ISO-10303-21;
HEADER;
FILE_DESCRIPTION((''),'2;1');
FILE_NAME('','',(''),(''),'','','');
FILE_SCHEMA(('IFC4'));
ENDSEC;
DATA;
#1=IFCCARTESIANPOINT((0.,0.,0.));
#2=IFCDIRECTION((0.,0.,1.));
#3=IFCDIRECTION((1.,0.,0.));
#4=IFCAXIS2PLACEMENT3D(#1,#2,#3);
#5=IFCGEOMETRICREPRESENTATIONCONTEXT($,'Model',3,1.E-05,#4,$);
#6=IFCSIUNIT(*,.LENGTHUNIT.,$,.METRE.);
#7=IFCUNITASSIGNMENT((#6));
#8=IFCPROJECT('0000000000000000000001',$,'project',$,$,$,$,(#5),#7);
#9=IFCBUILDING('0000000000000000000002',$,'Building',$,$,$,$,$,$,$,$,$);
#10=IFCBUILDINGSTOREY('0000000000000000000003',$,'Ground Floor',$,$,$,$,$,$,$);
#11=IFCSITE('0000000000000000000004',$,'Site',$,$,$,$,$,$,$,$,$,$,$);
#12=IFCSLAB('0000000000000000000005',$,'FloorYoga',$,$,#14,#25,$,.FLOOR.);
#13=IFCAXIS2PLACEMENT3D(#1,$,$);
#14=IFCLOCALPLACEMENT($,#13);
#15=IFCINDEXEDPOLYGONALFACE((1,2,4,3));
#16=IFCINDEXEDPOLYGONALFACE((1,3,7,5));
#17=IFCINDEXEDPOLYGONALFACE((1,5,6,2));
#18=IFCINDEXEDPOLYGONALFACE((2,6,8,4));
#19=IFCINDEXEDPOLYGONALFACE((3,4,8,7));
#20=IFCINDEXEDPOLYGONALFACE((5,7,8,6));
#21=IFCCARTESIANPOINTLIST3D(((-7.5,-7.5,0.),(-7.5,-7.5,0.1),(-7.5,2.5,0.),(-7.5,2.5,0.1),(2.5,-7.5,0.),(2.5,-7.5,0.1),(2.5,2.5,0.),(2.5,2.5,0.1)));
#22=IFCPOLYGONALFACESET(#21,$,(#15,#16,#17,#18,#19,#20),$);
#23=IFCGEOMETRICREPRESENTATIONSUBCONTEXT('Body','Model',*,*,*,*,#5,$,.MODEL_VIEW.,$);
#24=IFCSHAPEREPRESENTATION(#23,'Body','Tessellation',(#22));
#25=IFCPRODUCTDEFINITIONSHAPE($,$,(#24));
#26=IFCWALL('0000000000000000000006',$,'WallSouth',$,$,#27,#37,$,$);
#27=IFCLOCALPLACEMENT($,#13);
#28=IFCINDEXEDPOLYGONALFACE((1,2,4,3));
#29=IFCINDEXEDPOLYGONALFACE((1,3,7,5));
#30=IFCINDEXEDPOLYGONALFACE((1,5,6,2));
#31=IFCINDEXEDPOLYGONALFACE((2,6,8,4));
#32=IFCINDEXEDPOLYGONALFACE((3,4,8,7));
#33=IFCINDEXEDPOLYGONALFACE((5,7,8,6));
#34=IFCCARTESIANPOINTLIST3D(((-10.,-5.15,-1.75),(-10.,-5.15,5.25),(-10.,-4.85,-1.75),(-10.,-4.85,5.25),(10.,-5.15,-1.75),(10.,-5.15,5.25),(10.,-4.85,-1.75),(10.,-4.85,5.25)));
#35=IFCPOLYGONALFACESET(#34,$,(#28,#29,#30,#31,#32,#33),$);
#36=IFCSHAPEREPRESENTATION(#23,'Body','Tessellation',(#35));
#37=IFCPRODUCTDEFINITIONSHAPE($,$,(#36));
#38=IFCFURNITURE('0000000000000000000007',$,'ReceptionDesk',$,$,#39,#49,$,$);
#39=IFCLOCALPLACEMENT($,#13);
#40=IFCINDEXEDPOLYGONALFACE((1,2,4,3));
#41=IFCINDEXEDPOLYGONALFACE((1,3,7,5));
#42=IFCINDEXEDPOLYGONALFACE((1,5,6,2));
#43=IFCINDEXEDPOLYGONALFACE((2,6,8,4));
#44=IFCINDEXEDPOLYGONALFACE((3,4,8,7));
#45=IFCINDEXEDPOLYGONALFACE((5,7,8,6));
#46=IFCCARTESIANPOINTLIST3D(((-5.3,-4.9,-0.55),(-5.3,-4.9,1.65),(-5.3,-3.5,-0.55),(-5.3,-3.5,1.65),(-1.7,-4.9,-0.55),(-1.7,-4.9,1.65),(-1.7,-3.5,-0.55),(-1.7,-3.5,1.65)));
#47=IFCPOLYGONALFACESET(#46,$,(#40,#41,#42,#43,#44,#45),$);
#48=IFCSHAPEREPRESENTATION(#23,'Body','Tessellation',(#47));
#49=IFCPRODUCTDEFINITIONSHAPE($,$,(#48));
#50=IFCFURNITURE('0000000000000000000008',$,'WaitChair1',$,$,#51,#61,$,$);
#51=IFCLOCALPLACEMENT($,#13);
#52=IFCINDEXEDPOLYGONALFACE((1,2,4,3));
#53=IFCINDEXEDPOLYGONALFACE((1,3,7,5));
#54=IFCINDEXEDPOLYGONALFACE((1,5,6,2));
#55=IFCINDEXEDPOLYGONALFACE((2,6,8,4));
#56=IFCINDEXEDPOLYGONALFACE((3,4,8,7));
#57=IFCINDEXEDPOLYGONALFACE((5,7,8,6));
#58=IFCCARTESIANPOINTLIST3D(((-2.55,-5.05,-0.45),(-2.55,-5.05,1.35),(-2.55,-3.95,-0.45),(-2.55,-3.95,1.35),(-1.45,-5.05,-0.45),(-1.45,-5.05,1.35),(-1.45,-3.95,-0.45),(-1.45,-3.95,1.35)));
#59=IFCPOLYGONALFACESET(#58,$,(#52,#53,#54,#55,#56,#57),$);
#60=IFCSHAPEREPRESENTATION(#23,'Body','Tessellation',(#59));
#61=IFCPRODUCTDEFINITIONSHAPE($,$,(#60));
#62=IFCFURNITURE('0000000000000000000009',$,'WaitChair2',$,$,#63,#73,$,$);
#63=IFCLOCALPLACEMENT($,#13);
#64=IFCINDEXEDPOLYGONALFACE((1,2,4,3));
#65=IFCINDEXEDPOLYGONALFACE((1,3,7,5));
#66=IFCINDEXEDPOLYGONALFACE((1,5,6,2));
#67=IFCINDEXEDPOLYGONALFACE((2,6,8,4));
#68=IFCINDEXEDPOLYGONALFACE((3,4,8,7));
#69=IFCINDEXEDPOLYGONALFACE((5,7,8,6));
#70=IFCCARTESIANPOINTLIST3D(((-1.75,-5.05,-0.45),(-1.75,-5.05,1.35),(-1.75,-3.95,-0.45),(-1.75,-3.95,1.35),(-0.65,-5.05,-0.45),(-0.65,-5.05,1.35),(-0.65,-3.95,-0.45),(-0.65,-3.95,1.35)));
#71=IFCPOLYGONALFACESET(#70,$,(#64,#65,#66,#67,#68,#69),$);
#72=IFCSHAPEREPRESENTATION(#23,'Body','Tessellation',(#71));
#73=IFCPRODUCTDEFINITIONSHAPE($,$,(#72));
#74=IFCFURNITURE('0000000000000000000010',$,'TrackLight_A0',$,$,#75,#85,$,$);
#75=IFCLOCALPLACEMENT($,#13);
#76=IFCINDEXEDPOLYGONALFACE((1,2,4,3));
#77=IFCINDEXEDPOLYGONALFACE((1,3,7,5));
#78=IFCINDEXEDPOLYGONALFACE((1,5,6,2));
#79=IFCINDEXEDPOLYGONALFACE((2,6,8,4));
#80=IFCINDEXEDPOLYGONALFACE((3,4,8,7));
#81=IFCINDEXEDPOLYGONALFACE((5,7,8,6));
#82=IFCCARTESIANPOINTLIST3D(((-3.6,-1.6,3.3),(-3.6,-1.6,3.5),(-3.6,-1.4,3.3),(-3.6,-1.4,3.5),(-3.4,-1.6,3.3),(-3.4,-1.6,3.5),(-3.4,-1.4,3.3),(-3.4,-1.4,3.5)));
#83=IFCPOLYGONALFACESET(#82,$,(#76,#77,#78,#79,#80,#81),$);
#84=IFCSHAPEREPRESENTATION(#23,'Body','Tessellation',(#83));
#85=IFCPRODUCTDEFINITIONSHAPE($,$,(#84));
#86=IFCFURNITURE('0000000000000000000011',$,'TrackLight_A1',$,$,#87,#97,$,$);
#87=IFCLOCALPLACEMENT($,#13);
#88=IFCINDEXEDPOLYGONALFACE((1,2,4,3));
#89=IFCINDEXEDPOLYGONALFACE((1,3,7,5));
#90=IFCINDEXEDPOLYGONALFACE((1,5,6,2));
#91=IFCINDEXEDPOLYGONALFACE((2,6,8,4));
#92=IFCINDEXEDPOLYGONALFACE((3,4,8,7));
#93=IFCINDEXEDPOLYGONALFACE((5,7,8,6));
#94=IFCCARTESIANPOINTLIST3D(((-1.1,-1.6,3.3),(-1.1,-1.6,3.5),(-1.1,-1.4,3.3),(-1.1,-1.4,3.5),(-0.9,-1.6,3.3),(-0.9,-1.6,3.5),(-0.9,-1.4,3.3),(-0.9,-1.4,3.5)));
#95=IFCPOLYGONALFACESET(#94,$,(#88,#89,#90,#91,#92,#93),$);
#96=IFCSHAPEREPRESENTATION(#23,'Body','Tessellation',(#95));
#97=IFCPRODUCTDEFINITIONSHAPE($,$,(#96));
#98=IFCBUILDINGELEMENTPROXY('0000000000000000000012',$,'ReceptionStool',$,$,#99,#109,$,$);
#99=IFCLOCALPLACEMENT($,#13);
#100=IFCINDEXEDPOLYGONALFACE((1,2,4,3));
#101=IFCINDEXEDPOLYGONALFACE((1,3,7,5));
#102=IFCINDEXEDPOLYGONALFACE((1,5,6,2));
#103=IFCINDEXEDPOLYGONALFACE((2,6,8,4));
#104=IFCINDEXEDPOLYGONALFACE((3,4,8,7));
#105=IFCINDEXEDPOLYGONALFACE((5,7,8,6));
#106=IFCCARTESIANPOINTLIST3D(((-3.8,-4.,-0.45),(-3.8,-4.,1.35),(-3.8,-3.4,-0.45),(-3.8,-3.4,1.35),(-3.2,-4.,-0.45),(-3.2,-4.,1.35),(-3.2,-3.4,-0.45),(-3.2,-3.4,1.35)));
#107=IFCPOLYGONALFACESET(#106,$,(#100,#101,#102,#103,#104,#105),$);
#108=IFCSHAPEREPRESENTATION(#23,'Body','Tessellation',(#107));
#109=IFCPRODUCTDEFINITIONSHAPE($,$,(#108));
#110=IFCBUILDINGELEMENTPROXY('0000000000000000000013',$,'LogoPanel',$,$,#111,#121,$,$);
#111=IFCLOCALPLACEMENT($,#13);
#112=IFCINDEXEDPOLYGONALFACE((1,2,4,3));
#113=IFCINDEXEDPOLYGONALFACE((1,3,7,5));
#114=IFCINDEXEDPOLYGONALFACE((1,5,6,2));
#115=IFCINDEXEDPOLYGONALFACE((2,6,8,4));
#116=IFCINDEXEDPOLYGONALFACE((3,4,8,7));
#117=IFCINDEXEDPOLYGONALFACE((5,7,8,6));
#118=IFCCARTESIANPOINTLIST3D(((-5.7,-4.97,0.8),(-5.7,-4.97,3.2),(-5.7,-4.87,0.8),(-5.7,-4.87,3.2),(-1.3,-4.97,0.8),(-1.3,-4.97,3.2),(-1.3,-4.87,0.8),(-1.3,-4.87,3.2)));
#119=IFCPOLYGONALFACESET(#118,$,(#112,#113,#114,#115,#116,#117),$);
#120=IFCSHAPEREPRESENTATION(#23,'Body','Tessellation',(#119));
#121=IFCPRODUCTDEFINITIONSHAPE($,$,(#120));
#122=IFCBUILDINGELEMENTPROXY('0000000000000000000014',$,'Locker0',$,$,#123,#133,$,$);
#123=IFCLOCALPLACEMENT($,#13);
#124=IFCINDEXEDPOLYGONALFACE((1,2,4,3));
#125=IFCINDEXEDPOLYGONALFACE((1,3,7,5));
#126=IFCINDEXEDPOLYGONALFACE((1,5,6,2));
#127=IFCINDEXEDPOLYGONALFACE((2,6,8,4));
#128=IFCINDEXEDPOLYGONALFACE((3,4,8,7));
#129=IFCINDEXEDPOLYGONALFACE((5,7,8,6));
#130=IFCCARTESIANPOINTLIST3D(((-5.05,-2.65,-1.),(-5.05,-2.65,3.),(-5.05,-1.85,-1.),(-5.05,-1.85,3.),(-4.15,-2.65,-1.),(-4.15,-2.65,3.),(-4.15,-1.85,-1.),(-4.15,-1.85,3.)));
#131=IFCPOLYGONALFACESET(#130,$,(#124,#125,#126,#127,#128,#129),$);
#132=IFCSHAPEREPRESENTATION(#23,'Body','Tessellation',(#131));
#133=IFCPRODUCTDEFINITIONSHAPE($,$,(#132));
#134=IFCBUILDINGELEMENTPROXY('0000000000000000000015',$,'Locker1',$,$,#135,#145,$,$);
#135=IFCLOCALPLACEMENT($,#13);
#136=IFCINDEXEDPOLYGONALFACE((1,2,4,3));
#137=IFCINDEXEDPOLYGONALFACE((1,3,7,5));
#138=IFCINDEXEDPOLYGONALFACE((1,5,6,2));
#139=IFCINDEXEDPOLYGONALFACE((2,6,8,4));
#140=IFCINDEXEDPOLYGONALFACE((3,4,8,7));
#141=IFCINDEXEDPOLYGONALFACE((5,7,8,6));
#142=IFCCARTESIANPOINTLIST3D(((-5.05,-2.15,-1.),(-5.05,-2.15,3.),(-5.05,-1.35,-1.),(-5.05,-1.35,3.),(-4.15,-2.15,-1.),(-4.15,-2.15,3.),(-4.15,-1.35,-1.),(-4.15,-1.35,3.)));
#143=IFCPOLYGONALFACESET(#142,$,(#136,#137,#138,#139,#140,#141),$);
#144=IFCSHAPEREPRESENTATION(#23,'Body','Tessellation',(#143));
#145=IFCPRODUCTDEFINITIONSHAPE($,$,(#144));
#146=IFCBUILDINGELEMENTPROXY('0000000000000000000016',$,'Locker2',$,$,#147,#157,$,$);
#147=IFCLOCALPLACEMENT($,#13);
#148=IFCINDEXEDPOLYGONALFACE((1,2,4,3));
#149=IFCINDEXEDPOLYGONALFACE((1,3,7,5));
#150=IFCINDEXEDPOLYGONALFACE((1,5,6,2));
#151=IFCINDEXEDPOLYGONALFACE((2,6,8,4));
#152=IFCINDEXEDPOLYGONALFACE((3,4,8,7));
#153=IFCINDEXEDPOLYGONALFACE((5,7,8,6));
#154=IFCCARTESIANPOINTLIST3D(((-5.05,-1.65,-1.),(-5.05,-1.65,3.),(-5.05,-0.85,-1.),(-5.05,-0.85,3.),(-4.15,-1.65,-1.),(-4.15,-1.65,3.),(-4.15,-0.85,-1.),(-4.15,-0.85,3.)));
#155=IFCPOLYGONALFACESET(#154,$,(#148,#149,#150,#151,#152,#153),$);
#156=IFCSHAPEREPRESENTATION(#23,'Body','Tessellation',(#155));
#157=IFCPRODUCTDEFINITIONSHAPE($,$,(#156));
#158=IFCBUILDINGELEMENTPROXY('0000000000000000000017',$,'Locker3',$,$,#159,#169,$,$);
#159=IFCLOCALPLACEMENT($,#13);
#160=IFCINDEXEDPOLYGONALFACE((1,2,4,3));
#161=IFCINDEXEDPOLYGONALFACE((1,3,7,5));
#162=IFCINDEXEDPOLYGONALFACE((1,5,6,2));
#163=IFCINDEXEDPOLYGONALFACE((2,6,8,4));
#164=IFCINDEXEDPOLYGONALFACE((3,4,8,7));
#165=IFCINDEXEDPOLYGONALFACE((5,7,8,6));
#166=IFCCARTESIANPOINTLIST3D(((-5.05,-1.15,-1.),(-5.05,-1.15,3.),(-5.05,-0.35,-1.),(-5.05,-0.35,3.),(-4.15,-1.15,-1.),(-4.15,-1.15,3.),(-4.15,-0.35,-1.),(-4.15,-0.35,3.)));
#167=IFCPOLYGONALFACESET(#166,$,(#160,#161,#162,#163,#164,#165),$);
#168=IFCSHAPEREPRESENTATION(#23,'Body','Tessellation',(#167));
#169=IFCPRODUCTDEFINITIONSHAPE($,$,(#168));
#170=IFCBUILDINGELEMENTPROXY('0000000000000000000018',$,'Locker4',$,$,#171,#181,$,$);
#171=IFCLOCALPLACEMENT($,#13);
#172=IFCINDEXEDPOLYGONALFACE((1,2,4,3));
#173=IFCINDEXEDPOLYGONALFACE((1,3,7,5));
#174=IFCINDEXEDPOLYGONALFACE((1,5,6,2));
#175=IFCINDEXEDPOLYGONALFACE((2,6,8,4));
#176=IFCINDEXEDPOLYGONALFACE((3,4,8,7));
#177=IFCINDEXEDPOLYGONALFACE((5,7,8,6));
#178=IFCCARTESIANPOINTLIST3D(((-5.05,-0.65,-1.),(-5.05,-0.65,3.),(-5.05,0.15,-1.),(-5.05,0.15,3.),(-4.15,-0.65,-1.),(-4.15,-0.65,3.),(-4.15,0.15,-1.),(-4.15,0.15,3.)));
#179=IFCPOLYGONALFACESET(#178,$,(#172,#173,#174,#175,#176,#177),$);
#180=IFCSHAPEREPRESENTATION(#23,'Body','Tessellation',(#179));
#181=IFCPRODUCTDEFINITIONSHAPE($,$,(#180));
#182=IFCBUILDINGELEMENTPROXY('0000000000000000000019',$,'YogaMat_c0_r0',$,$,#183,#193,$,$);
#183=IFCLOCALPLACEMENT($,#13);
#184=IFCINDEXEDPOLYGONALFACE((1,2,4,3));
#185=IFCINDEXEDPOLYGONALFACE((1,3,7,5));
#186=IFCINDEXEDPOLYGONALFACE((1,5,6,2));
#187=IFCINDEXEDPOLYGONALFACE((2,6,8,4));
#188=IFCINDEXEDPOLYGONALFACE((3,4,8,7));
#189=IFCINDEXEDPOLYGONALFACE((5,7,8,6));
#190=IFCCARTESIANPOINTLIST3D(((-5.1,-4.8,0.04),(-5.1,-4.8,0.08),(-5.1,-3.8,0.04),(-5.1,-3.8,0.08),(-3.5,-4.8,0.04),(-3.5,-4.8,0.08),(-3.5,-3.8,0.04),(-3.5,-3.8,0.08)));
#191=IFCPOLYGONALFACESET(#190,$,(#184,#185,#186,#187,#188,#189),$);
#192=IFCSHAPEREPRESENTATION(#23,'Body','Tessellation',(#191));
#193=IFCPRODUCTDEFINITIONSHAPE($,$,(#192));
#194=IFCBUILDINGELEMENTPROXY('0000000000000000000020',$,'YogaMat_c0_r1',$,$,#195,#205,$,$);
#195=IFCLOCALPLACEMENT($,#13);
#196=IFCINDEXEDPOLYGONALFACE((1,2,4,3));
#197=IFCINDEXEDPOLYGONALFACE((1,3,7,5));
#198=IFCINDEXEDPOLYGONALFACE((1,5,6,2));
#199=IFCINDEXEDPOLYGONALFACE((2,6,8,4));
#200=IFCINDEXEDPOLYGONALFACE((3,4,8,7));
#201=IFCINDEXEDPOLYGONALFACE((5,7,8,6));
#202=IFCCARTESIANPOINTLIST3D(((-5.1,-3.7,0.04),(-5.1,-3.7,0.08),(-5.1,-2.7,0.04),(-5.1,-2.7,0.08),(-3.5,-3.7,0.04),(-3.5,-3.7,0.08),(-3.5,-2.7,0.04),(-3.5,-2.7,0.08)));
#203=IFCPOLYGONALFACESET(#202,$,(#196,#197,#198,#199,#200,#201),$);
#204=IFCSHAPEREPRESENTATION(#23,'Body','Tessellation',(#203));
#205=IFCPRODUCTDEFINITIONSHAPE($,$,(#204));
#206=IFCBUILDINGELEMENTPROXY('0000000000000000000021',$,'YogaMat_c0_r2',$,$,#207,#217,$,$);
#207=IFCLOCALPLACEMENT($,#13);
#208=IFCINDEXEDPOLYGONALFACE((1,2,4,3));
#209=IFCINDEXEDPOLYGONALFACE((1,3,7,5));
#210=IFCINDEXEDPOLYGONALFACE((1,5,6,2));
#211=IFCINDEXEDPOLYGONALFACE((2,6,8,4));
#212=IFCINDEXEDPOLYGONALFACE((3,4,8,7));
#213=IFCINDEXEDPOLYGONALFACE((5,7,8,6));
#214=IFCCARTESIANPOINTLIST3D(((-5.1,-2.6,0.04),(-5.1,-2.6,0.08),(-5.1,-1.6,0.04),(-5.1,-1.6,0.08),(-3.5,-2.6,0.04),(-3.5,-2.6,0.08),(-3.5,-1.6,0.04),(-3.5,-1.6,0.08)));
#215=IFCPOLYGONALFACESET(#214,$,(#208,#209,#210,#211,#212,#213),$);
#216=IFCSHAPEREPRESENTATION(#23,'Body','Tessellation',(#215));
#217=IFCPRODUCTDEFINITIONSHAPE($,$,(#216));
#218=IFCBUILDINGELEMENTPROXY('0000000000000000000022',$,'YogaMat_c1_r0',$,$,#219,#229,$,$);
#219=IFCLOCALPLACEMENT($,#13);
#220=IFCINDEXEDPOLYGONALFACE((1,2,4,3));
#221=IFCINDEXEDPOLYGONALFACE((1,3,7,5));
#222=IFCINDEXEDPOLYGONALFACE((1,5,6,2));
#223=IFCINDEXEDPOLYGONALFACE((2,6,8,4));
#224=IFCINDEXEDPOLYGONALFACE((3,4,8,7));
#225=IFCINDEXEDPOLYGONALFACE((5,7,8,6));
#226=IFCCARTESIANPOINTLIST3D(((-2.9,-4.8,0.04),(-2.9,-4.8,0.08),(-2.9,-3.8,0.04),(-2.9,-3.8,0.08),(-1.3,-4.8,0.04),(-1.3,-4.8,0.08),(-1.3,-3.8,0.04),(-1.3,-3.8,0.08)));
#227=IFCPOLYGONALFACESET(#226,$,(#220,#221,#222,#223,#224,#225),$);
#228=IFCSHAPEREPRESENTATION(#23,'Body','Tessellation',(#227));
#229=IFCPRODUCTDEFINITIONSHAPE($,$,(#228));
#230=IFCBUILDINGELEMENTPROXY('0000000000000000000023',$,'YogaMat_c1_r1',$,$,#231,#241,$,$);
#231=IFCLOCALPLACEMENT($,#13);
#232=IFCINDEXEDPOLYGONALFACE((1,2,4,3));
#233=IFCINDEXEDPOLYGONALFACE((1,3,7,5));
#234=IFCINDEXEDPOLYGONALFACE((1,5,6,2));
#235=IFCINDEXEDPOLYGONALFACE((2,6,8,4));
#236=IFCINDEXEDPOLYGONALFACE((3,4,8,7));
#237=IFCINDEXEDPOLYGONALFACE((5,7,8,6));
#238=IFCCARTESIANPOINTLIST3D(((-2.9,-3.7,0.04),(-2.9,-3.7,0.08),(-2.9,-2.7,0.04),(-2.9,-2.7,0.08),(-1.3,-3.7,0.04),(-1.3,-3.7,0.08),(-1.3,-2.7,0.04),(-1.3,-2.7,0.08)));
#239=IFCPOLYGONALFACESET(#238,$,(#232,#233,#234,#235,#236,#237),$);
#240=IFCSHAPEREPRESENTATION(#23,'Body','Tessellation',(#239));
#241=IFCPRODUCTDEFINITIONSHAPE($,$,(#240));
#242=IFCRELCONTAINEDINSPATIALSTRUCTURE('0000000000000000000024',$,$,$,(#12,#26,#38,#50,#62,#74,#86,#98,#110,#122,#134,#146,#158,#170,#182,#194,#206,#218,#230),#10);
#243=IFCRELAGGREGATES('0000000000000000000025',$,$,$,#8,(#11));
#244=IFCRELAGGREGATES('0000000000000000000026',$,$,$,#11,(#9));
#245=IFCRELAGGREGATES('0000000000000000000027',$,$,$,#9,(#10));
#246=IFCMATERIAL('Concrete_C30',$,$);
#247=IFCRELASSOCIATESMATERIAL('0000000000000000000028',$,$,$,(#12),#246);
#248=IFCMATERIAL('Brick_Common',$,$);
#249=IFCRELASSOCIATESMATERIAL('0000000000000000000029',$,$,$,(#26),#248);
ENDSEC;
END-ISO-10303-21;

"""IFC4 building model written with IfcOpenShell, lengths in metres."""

from ifc_helpers import new_model, si_unit, frame, origin_with_axes, origin_2d, place, context, subcontext, project, spatial, rectangle, extrude, material, element, save


model = new_model("IFC4")

# Units and contexts
model_context = context("Model", 3, precision=1e-05, world=origin_with_axes())
body_context = subcontext(model_context, "Body", "Model", "MODEL_VIEW")
ifc_project = project(units=[si_unit("LENGTHUNIT", "METRE")], contexts=[model_context])

# Site, building, storey
site = spatial("IfcSite", under=ifc_project, Name="Site")
building = spatial("IfcBuilding", under=site, Name="Building")
storey = spatial("IfcBuildingStorey", under=building, Name="Ground Floor")

# Slab
ifc_material_1 = material(Name="Concrete_C30")
slab_placement = place(None, frame((-2.5, -2.5, 0.05), z_axis=(0.0, 0.0, 1.0), x_axis=(1.0, 0.0, 0.0)))
element("IfcSlab", 1, at=slab_placement, inside=storey, material=ifc_material_1, Name="FloorYoga", PredefinedType="FLOOR", context=body_context, shape_type="SweptSolid", body=[
    extrude(rectangle(XDim=10.0, YDim=10.0, at=origin_2d()), frame((0.0, 0.0, -0.05)), (0.0, 0.0, 1.0), 0.1),
])

# Wall
ifc_material_2 = material(Name="Brick_Common")
wall_placement = place(None, frame((0.0, -5.0, 1.75), z_axis=(0.0, 0.0, 1.0), x_axis=(1.0, 0.0, 0.0)))
element("IfcWall", 2, at=wall_placement, inside=storey, material=ifc_material_2, Name="WallSouth", context=body_context, shape_type="SweptSolid", body=[
    extrude(rectangle(XDim=20.0, YDim=0.3, at=origin_2d()), frame((0.0, 0.0, -3.5)), (0.0, 0.0, 1.0), 7.0),
])

# Furniture
furniture_placement = place(None, frame((-3.5, -4.2, 0.55), z_axis=(0.0, 0.0, 1.0), x_axis=(1.0, 0.0, 0.0)))
element("IfcFurniture", 3, at=furniture_placement, inside=storey, Name="ReceptionDesk", context=body_context, shape_type="SweptSolid", body=[
    extrude(rectangle(XDim=3.6, YDim=1.4, at=origin_2d()), frame((0.0, 0.0, -1.1)), (0.0, 0.0, 1.0), 2.2),
])
for number, where, z_axis, x_axis, name in (
    (4, (-2.0, -4.5, 0.45), (0.0, 0.0, 1.0), (1.0, 0.0, 0.0), "WaitChair1"),
    (5, (-1.2, -4.5, 0.45), (0.0, 0.0, 1.0), (1.0, 0.0, 0.0), "WaitChair2"),
):
    element("IfcFurniture", number, at=place(None, frame(where, z_axis=z_axis, x_axis=x_axis)), inside=storey, Name=name, context=body_context, shape_type="SweptSolid", body=[
        extrude(rectangle(XDim=1.1, YDim=1.1, at=origin_2d()), frame((0.0, 0.0, -0.9)), (0.0, 0.0, 1.0), 1.8),
    ])
for number, where, z_axis, x_axis, name in (
    (6, (-3.5, -1.5, 3.4), (0.0, 0.0, 1.0), (1.0, 0.0, 0.0), "TrackLight_A0"),
    (7, (-1.0, -1.5, 3.4), (0.0, 0.0, 1.0), (1.0, 0.0, 0.0), "TrackLight_A1"),
):
    element("IfcFurniture", number, at=place(None, frame(where, z_axis=z_axis, x_axis=x_axis)), inside=storey, Name=name, context=body_context, shape_type="SweptSolid", body=[
        extrude(rectangle(XDim=0.2, YDim=0.2, at=origin_2d()), frame((0.0, 0.0, -0.1)), (0.0, 0.0, 1.0), 0.2),
    ])

# Building element proxies
proxy_1_placement = place(None, frame((-3.5, -3.7, 0.45), z_axis=(0.0, 0.0, 1.0), x_axis=(1.0, 0.0, 0.0)))
element("IfcBuildingElementProxy", 8, at=proxy_1_placement, inside=storey, Name="ReceptionStool", context=body_context, shape_type="SweptSolid", body=[
    extrude(rectangle(XDim=0.6, YDim=0.6, at=origin_2d()), frame((0.0, 0.0, -0.9)), (0.0, 0.0, 1.0), 1.8),
])
proxy_2_placement = place(None, frame((-3.5, -4.92, 2.0), z_axis=(0.0, 0.0, 1.0), x_axis=(1.0, 0.0, 0.0)))
element("IfcBuildingElementProxy", 9, at=proxy_2_placement, inside=storey, Name="LogoPanel", context=body_context, shape_type="SweptSolid", body=[
    extrude(rectangle(XDim=4.4, YDim=0.1, at=origin_2d()), frame((0.0, 0.0, -1.2)), (0.0, 0.0, 1.0), 2.4),
])
for number, where, z_axis, x_axis, name in (
    (10, (-4.6, -2.25, 1.0), (0.0, 0.0, 1.0), (1.0, 0.0, 0.0), "Locker0"),
    (11, (-4.6, -1.75, 1.0), (0.0, 0.0, 1.0), (1.0, 0.0, 0.0), "Locker1"),
    (12, (-4.6, -1.25, 1.0), (0.0, 0.0, 1.0), (1.0, 0.0, 0.0), "Locker2"),
    (13, (-4.6, -0.75, 1.0), (0.0, 0.0, 1.0), (1.0, 0.0, 0.0), "Locker3"),
    (14, (-4.6, -0.25, 1.0), (0.0, 0.0, 1.0), (1.0, 0.0, 0.0), "Locker4"),
):
    element("IfcBuildingElementProxy", number, at=place(None, frame(where, z_axis=z_axis, x_axis=x_axis)), inside=storey, Name=name, context=body_context, shape_type="SweptSolid", body=[
        extrude(rectangle(XDim=0.9, YDim=0.8, at=origin_2d()), frame((0.0, 0.0, -2.0)), (0.0, 0.0, 1.0), 4.0),
    ])
for number, where, z_axis, x_axis, name in (
    (15, (-4.3, -4.3, 0.06), (0.0, 0.0, 1.0), (1.0, 0.0, 0.0), "YogaMat_c0_r0"),
    (16, (-4.3, -3.2, 0.06), (0.0, 0.0, 1.0), (1.0, 0.0, 0.0), "YogaMat_c0_r1"),
    (17, (-4.3, -2.1, 0.06), (0.0, 0.0, 1.0), (1.0, 0.0, 0.0), "YogaMat_c0_r2"),
    (18, (-2.1, -4.3, 0.06), (0.0, 0.0, 1.0), (1.0, 0.0, 0.0), "YogaMat_c1_r0"),
    (19, (-2.1, -3.2, 0.06), (0.0, 0.0, 1.0), (1.0, 0.0, 0.0), "YogaMat_c1_r1"),
):
    element("IfcBuildingElementProxy", number, at=place(None, frame(where, z_axis=z_axis, x_axis=x_axis)), inside=storey, Name=name, context=body_context, shape_type="SweptSolid", body=[
        extrude(rectangle(XDim=1.6, YDim=1.0, at=origin_2d()), frame((0.0, 0.0, -0.02)), (0.0, 0.0, 1.0), 0.04),
    ])

save(model, "model.ifc")
